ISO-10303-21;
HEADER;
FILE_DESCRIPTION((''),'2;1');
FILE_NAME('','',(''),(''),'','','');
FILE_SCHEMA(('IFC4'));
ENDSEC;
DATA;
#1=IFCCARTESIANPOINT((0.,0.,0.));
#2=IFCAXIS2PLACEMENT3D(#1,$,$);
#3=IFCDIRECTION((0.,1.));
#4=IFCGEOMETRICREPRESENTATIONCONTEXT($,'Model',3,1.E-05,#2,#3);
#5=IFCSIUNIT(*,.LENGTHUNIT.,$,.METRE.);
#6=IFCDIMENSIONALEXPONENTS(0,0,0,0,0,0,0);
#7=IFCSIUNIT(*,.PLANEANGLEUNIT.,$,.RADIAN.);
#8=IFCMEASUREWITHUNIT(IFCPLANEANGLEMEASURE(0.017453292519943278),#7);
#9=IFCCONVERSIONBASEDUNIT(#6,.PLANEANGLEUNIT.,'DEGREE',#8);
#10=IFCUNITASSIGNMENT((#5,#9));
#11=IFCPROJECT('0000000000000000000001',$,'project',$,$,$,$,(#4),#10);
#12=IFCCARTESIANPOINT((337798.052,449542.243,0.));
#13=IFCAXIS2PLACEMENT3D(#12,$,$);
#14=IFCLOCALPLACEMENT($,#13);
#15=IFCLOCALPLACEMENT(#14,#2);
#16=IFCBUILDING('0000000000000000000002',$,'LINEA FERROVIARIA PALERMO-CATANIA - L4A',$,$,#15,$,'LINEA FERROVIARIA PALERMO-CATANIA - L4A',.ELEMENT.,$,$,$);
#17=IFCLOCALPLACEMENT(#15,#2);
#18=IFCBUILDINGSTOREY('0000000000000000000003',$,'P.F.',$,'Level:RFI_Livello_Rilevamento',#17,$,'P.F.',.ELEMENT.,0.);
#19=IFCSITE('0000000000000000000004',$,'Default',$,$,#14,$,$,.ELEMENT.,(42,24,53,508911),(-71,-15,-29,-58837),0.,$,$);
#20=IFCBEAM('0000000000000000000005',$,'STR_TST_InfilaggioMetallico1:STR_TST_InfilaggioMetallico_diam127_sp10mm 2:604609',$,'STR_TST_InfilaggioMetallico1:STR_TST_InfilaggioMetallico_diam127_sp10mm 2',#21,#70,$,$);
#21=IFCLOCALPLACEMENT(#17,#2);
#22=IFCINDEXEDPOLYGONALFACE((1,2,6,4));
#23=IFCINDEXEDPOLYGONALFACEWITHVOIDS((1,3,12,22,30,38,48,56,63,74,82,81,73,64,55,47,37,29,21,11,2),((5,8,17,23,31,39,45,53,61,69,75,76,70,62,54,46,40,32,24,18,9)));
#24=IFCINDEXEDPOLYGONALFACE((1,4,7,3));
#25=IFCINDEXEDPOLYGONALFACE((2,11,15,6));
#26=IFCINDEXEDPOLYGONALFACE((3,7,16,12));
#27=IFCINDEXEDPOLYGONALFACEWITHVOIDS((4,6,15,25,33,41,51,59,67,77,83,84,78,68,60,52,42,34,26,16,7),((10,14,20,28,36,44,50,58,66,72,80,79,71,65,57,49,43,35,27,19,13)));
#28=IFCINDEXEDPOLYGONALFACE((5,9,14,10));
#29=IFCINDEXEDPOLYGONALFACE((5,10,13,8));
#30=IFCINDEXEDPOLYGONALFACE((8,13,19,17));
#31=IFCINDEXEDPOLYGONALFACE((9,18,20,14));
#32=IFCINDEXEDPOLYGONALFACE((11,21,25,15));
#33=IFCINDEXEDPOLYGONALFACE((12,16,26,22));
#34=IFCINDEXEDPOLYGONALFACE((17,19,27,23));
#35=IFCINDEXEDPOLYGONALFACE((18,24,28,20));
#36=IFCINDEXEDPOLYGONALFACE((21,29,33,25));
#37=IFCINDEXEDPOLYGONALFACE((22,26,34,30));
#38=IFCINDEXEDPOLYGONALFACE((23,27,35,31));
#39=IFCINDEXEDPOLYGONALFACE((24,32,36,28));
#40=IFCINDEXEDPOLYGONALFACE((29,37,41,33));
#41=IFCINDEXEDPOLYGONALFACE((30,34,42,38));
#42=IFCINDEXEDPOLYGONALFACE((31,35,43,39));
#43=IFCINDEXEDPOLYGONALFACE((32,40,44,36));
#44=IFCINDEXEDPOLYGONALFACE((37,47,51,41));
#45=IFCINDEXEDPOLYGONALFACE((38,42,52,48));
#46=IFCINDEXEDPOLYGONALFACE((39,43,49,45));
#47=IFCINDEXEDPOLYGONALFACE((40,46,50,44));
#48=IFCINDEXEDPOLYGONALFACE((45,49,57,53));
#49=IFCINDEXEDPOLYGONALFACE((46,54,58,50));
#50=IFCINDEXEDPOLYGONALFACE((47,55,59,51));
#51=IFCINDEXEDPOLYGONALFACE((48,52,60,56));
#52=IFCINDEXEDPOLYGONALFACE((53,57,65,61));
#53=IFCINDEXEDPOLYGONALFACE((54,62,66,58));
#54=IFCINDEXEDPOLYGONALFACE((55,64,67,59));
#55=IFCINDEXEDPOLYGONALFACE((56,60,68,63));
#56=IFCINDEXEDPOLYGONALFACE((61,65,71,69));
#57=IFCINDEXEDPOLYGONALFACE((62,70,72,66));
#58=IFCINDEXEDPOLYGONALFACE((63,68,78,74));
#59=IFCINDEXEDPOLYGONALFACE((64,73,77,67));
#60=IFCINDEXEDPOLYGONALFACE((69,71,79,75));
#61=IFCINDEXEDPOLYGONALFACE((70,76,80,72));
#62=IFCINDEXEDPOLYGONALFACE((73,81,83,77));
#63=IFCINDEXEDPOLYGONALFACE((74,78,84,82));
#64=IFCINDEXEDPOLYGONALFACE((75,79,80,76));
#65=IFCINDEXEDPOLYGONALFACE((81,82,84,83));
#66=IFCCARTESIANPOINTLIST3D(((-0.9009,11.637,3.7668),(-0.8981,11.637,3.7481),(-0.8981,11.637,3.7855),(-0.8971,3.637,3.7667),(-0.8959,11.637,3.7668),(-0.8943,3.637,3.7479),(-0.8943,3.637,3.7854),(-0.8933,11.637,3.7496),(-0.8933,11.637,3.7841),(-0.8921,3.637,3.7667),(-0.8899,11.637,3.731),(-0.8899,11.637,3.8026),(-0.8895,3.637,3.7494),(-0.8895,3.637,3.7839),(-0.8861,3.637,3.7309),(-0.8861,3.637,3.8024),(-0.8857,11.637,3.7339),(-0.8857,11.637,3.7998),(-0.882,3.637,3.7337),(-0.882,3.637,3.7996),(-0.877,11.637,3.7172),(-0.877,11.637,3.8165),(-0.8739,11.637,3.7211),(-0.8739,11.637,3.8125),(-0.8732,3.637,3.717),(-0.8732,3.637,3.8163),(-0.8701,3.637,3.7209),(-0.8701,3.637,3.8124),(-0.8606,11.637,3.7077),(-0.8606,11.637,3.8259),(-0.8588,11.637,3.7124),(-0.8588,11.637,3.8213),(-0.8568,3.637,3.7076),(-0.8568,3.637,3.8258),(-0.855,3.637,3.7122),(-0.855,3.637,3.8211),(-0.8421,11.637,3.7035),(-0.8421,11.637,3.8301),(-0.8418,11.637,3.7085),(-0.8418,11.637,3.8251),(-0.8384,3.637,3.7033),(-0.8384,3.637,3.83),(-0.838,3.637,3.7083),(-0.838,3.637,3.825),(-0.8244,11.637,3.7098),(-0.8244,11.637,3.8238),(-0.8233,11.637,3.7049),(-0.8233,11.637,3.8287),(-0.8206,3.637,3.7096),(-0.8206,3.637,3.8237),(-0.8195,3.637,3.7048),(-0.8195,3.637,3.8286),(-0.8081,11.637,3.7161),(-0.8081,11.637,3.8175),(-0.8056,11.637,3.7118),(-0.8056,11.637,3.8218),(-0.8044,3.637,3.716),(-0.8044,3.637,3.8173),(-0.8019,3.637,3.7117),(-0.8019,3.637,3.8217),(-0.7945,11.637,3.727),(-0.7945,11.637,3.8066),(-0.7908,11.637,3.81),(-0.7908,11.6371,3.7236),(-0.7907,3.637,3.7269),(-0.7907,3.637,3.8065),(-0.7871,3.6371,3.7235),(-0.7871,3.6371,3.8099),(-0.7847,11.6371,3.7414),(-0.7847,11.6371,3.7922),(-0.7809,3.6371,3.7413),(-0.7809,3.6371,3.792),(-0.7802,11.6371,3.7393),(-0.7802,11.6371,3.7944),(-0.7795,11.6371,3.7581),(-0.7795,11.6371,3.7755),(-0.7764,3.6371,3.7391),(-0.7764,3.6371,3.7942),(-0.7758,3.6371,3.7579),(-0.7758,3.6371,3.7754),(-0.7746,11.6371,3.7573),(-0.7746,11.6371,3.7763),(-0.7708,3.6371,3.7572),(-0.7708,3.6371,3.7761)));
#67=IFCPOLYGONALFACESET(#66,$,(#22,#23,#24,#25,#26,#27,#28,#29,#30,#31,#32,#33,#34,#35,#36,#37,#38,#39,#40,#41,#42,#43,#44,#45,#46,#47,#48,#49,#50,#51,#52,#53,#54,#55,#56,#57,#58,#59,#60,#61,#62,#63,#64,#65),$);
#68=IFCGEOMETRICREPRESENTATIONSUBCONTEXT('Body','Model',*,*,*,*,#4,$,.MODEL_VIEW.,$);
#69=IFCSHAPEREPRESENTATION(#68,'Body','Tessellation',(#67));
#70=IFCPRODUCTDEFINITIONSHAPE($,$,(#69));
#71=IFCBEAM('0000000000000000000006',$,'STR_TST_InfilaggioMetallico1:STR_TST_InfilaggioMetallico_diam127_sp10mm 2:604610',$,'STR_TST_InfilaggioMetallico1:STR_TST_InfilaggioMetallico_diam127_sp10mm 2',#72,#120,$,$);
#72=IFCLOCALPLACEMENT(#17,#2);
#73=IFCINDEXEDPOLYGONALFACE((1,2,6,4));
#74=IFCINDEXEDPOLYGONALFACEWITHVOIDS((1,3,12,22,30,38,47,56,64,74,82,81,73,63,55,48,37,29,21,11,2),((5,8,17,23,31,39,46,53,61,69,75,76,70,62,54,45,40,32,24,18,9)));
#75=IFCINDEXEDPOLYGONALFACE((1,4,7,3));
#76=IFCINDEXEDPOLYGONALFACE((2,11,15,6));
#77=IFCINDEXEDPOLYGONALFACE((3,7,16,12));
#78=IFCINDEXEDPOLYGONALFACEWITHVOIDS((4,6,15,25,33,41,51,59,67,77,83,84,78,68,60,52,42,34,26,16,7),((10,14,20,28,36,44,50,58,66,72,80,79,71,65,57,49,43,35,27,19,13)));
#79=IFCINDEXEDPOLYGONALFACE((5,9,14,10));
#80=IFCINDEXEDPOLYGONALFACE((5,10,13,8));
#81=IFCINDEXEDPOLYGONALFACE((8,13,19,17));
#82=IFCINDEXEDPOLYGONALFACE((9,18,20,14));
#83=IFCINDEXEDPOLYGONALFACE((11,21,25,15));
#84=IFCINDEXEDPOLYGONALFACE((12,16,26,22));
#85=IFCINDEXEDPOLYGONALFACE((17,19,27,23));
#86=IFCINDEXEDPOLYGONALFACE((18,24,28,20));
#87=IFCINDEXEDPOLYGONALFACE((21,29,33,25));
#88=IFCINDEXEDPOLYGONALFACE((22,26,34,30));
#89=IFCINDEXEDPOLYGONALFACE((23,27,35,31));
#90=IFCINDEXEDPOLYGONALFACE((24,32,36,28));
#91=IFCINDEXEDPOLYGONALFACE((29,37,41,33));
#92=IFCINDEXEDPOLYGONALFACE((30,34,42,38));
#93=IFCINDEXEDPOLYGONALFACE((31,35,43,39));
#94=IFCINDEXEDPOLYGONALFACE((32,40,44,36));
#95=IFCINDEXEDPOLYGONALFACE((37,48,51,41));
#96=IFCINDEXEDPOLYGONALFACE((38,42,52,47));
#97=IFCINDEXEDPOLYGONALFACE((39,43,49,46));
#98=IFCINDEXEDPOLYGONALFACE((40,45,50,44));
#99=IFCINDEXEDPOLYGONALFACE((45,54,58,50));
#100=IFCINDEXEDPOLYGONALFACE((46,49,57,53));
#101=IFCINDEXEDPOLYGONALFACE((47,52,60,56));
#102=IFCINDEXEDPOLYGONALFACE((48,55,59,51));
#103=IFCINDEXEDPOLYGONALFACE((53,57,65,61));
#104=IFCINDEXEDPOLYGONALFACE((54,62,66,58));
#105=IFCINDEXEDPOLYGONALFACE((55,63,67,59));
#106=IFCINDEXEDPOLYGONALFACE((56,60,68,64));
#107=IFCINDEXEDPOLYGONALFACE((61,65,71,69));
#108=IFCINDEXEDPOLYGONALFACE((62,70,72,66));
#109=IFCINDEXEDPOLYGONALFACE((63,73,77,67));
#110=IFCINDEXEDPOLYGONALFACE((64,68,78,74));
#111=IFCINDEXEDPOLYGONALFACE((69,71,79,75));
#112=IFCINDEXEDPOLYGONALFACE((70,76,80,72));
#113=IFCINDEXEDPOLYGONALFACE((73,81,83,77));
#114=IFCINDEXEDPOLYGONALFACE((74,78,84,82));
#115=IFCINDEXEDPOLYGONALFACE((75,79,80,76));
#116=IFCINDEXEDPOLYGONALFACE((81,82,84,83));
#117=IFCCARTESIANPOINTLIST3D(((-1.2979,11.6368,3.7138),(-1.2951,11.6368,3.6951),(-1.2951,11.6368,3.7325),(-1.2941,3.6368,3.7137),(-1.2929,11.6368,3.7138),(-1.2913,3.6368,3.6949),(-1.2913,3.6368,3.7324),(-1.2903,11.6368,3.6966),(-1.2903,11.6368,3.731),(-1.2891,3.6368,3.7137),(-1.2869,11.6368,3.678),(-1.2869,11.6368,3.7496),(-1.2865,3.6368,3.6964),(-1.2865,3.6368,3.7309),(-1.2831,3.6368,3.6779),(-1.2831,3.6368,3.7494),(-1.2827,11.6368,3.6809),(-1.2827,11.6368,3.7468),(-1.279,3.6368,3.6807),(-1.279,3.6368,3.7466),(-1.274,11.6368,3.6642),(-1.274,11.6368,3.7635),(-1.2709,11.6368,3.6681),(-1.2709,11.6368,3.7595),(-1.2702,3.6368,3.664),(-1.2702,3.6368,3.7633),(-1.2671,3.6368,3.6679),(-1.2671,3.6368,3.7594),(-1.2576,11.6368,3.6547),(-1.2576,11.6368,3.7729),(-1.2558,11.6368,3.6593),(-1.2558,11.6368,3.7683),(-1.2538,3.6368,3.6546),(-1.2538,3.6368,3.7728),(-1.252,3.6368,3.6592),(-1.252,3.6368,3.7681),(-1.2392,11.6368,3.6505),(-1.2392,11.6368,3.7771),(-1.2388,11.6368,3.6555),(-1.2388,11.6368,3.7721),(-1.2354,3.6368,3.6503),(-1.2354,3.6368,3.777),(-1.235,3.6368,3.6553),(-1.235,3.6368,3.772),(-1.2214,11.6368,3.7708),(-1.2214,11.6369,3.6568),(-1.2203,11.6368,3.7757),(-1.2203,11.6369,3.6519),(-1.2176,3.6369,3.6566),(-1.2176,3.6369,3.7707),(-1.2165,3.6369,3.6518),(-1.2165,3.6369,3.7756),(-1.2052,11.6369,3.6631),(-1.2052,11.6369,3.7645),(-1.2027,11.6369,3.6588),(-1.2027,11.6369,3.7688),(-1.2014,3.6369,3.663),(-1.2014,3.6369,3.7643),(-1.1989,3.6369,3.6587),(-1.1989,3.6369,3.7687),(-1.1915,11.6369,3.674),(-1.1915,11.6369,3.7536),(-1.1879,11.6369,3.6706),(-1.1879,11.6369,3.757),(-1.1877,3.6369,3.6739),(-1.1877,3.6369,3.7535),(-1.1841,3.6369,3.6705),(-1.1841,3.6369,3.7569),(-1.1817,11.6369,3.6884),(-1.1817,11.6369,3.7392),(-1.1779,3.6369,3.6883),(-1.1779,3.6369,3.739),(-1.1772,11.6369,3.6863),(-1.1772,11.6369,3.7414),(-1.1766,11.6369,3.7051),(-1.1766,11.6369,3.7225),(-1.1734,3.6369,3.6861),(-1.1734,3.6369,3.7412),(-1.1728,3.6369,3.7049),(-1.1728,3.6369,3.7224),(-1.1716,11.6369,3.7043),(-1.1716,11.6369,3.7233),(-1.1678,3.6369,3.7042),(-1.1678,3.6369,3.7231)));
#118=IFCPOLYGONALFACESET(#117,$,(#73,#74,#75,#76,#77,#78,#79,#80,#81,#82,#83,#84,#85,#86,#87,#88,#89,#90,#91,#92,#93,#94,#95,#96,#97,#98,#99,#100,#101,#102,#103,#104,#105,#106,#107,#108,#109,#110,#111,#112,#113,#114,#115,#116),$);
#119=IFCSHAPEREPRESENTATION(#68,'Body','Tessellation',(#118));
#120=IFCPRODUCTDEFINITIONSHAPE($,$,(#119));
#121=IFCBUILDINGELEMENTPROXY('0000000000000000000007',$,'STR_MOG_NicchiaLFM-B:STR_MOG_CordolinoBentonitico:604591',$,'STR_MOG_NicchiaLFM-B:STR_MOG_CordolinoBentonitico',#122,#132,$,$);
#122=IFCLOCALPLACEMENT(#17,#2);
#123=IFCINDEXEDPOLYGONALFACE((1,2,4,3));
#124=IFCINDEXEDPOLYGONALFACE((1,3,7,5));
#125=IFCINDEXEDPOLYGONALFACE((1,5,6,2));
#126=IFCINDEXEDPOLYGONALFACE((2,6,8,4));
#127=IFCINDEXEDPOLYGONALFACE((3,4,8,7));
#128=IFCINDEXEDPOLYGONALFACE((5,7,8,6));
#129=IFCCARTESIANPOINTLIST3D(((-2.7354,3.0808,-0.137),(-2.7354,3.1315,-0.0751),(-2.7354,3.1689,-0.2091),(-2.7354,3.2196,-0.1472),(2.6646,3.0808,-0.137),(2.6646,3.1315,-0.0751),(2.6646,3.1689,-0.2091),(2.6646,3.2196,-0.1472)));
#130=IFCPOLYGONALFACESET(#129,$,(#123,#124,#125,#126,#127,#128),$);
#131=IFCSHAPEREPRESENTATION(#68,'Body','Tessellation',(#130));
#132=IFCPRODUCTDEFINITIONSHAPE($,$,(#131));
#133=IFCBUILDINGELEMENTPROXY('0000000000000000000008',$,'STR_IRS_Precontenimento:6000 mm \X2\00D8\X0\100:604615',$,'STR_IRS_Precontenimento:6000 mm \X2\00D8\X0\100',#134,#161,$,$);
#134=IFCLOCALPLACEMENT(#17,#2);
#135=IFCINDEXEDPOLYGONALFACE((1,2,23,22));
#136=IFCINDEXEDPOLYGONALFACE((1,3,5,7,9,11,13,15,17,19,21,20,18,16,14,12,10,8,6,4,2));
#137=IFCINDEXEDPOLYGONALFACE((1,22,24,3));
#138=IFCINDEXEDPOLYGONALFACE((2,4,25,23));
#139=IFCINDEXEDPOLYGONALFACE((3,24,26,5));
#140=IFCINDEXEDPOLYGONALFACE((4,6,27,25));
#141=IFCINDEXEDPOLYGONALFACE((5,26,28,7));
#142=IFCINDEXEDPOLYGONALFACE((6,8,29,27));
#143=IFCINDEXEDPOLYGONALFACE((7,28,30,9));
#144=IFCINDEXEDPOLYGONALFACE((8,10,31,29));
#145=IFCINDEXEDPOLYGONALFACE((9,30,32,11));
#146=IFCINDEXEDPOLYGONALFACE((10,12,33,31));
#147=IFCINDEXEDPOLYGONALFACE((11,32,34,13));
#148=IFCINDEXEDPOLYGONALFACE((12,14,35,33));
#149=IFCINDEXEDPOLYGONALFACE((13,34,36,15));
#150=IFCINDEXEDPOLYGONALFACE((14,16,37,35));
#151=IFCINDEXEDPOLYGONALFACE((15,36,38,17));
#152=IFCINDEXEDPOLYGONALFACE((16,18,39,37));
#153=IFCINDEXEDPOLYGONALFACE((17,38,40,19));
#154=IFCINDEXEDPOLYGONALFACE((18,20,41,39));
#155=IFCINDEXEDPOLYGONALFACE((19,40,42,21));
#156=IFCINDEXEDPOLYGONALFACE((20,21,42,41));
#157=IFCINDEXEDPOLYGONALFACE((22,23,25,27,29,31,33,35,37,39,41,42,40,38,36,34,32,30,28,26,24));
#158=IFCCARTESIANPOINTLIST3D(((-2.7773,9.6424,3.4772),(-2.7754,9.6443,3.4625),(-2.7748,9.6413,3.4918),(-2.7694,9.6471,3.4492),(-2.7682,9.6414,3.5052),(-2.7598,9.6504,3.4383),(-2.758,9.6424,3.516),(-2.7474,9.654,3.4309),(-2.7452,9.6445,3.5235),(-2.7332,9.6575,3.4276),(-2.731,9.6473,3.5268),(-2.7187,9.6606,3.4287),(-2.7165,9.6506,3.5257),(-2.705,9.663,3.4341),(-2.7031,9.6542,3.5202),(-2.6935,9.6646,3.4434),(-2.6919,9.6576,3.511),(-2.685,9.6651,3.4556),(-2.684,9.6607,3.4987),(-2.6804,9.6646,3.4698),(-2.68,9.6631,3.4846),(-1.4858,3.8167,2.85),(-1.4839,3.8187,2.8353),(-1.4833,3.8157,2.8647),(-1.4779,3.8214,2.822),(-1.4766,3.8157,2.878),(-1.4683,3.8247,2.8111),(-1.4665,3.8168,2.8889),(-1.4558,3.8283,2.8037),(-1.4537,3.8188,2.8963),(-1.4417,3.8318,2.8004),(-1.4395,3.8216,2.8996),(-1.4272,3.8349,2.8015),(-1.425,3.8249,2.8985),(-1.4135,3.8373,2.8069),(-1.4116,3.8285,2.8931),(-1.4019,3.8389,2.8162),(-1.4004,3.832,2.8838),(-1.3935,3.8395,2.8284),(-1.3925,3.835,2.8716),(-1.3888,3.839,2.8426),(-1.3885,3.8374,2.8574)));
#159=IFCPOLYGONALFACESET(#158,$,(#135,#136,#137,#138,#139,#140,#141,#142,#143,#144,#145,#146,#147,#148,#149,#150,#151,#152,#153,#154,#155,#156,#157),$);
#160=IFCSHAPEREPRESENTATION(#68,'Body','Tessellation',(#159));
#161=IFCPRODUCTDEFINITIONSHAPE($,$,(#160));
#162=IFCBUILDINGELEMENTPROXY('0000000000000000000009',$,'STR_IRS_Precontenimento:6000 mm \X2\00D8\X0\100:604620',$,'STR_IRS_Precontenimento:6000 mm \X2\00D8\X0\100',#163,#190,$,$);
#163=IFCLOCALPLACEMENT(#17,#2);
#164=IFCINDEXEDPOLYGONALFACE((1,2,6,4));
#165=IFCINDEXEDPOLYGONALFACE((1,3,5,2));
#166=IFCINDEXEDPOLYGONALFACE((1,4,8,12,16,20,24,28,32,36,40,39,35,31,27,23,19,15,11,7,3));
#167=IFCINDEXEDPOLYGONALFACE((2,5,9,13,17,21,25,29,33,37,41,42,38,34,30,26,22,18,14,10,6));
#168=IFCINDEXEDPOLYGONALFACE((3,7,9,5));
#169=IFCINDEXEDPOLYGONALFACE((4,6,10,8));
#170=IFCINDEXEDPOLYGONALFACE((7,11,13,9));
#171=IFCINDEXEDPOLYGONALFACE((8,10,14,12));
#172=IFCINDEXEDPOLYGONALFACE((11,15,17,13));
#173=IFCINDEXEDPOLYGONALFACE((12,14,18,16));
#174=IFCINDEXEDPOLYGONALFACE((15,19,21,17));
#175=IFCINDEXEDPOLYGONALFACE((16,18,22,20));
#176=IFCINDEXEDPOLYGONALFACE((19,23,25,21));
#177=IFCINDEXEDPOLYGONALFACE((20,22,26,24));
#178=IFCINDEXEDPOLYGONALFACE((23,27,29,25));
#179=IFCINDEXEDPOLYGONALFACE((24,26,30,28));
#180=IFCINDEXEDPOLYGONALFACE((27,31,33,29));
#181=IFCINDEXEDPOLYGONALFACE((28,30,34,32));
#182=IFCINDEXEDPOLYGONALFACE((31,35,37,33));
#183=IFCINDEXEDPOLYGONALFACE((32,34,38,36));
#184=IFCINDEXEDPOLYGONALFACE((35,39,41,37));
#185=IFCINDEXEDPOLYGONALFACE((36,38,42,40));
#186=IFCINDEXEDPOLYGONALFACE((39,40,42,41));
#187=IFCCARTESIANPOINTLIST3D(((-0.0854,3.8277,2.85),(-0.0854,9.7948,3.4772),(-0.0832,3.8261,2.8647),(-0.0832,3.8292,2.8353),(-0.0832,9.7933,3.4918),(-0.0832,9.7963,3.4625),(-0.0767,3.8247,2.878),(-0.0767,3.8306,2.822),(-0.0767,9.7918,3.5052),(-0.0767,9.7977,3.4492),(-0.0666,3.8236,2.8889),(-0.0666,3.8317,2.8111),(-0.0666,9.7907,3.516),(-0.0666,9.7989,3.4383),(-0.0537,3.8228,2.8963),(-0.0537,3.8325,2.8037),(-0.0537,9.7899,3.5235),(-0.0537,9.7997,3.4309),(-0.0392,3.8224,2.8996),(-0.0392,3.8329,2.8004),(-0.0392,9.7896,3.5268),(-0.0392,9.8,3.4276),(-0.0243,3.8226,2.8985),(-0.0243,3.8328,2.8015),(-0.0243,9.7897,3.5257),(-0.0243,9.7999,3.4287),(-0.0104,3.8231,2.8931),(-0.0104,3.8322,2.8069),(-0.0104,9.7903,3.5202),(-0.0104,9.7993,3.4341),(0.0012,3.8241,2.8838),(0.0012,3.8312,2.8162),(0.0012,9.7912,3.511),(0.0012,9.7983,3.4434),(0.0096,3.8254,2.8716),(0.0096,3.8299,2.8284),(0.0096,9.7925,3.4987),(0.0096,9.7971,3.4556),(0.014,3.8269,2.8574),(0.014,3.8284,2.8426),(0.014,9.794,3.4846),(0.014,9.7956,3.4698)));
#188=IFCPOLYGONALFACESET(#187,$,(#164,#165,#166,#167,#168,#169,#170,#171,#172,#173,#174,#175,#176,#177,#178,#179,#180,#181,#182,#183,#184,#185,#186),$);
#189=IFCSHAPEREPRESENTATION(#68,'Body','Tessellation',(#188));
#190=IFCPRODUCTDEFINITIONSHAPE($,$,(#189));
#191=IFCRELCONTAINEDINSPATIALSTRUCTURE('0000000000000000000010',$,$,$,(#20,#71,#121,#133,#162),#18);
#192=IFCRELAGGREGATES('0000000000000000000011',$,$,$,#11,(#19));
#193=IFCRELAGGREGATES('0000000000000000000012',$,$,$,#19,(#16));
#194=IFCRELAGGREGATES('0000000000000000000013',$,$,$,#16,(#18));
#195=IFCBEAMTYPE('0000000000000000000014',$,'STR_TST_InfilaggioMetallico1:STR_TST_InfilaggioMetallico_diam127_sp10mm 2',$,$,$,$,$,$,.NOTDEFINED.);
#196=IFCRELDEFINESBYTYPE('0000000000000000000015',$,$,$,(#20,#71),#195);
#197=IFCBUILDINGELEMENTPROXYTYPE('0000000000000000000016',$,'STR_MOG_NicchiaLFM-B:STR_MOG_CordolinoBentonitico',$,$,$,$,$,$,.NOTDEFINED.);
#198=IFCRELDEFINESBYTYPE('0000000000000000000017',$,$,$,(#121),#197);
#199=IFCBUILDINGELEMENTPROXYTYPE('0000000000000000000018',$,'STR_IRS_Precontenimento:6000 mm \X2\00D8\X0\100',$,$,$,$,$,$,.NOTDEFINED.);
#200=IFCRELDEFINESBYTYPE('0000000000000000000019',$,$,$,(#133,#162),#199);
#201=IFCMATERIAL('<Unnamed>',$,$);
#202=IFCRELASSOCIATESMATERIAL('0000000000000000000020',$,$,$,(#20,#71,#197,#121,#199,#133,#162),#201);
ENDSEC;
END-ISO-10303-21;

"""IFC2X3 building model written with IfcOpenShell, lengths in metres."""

from ifc_helpers import new_model, entity, si_unit, converted_unit, direction, frame, frame_2d, origin, origin_2d_with_axis, place, context, subcontext, project, spatial, rectangle, circle, hollow_circle, extrude, source, transform, mapped, material, type_object, type_shapes, element, save


model = new_model("IFC2X3")

# Units and contexts
model_context = context("Model", 3, precision=1e-05, world=origin(), true_north=direction((0.0, 1.0)))
body_context = subcontext(model_context, "Body", "Model", "MODEL_VIEW")
ifc_project = project(units=[si_unit("LENGTHUNIT", "METRE"), converted_unit("PLANEANGLEUNIT", "DEGREE", entity("IfcPlaneAngleMeasure", 0.017453292519943278), si_unit("PLANEANGLEUNIT", "RADIAN"), dimensions=[0, 0, 0, 0, 0, 0, 0])], contexts=[model_context])

# Site, building, storey
site_placement = place(None, frame((337798.052, 449542.243, 0.0)))
site = spatial("IfcSite", under=ifc_project, at=site_placement, Name="Default", CompositionType="ELEMENT", RefLatitude=(42, 24, 53, 508911), RefLongitude=(-71, -15, -29, -58837), RefElevation=0.0)
building_placement = place(site_placement, origin())
building = spatial("IfcBuilding", under=site, at=building_placement, Name="LINEA FERROVIARIA PALERMO-CATANIA - L4A", LongName="LINEA FERROVIARIA PALERMO-CATANIA - L4A", CompositionType="ELEMENT")
storey_placement = place(building_placement, origin())
storey = spatial("IfcBuildingStorey", under=building, at=storey_placement, Name="P.F.", ObjectType="Level:RFI_Livello_Rilevamento", LongName="P.F.", CompositionType="ELEMENT", Elevation=0.0)

# Beams
ifc_material = material(Name="<Unnamed>")
beam_type = type_object("IfcBeamType", Name="STR_TST_InfilaggioMetallico1:STR_TST_InfilaggioMetallico_diam127_sp10mm 2", PredefinedType="NOTDEFINED")
beam_1_placement = place(storey_placement, frame((-0.9025, 3.637, 3.8319), z_axis=(0.0, -0.000018, 1.0), x_axis=(-0.00047, 1.0, 0.000018)))
element("IfcBeam", 1, at=beam_1_placement, inside=storey, type_object=beam_type, material=ifc_material, Name="STR_TST_InfilaggioMetallico1:STR_TST_InfilaggioMetallico_diam127_sp10mm 2:604609", ObjectType="STR_TST_InfilaggioMetallico1:STR_TST_InfilaggioMetallico_diam127_sp10mm 2", context=body_context, shape_type="SweptSolid", body=[
    extrude(hollow_circle(Radius=0.0635, WallThickness=0.005, at=origin_2d_with_axis()), frame((0.0, -0.0688, -0.0652), z_axis=(1.0, 0.0, 0.0), x_axis=(0.0, 1.0, 0.0)), (0.0, 0.0, 1.0), 8.0),
])
beam_2_placement = place(storey_placement, frame((-1.2995, 3.6368, 3.7789), z_axis=(0.0, -0.000018, 1.0), x_axis=(-0.000473, 1.0, 0.000018)))
element("IfcBeam", 2, at=beam_2_placement, inside=storey, type_object=beam_type, material=ifc_material, Name="STR_TST_InfilaggioMetallico1:STR_TST_InfilaggioMetallico_diam127_sp10mm 2:604610", ObjectType="STR_TST_InfilaggioMetallico1:STR_TST_InfilaggioMetallico_diam127_sp10mm 2", context=body_context, shape_type="SweptSolid", body=[
    extrude(hollow_circle(Radius=0.0635, WallThickness=0.005, at=origin_2d_with_axis()), frame((0.0, -0.0689, -0.0652), z_axis=(1.0, 0.0, 0.0), x_axis=(0.0, 1.0, 0.0)), (0.0, 0.0, 1.0), 8.0),
])

# Building element proxies
building_element_proxy_type_1 = type_object("IfcBuildingElementProxyType", Name="STR_MOG_NicchiaLFM-B:STR_MOG_CordolinoBentonitico", PredefinedType="NOTDEFINED", material=ifc_material)
shared_shape_1 = source(origin(), body_context, "Body", "SweptSolid", [
    extrude(rectangle(XDim=0.08, YDim=0.1139, at=frame_2d((0.0, 0.0), x_axis=(1.0, 0.0))), frame((-2.7, -4.9911, -0.1421), z_axis=(1.0, 0.0, 0.0), x_axis=(0.0, -0.633381, 0.77384)), (0.0, 0.0, 1.0), 5.4),
])
type_shapes(building_element_proxy_type_1, [shared_shape_1])
proxy_placement = place(storey_placement, frame((-0.0354, -1.841, 0.0), z_axis=(0.0, 0.0, 1.0), x_axis=(-1.0, 0.0, 0.0)))
element("IfcBuildingElementProxy", 3, at=proxy_placement, inside=storey, type_object=building_element_proxy_type_1, material=ifc_material, Name="STR_MOG_NicchiaLFM-B:STR_MOG_CordolinoBentonitico:604591", ObjectType="STR_MOG_NicchiaLFM-B:STR_MOG_CordolinoBentonitico", context=body_context, shape_type="MappedRepresentation", body=[
    mapped(shared_shape_1, transform((0.0, 0.0, 0.0), scale=1.0)),
])
building_element_proxy_type_2 = type_object("IfcBuildingElementProxyType", Name="STR_IRS_Precontenimento:6000 mm Ø100", PredefinedType="NOTDEFINED", material=ifc_material)
shared_shape_2 = source(origin(), body_context, "Body", "SweptSolid", [
    extrude(circle(Radius=0.05, at=frame_2d((0.0, 0.0), x_axis=(1.0, 0.0))), frame((0.0, 0.0, -6.0)), (0.0, 0.0, 1.0), 6.0),
])
type_shapes(building_element_proxy_type_2, [shared_shape_2])
for number, where, z_axis, x_axis, name in (
    (4, (-1.4369, 3.8275, 2.85), (0.215254, -0.970948, -0.104528), (-0.976296, -0.21644, 0.0), "STR_IRS_Precontenimento:6000 mm Ø100:604615"),
    (5, (-0.0354, 3.8277, 2.85), (0.0, -0.994522, -0.104528), (-1.0, 0.0, 0.0), "STR_IRS_Precontenimento:6000 mm Ø100:604620"),
):
    element("IfcBuildingElementProxy", number, at=place(storey_placement, frame(where, z_axis=z_axis, x_axis=x_axis)), inside=storey, type_object=building_element_proxy_type_2, material=ifc_material, Name=name, ObjectType="STR_IRS_Precontenimento:6000 mm Ø100", context=body_context, shape_type="MappedRepresentation", body=[
        mapped(shared_shape_2, transform((0.0, 0.0, 0.0), scale=1.0)),
    ])

save(model, "model.ifc")
